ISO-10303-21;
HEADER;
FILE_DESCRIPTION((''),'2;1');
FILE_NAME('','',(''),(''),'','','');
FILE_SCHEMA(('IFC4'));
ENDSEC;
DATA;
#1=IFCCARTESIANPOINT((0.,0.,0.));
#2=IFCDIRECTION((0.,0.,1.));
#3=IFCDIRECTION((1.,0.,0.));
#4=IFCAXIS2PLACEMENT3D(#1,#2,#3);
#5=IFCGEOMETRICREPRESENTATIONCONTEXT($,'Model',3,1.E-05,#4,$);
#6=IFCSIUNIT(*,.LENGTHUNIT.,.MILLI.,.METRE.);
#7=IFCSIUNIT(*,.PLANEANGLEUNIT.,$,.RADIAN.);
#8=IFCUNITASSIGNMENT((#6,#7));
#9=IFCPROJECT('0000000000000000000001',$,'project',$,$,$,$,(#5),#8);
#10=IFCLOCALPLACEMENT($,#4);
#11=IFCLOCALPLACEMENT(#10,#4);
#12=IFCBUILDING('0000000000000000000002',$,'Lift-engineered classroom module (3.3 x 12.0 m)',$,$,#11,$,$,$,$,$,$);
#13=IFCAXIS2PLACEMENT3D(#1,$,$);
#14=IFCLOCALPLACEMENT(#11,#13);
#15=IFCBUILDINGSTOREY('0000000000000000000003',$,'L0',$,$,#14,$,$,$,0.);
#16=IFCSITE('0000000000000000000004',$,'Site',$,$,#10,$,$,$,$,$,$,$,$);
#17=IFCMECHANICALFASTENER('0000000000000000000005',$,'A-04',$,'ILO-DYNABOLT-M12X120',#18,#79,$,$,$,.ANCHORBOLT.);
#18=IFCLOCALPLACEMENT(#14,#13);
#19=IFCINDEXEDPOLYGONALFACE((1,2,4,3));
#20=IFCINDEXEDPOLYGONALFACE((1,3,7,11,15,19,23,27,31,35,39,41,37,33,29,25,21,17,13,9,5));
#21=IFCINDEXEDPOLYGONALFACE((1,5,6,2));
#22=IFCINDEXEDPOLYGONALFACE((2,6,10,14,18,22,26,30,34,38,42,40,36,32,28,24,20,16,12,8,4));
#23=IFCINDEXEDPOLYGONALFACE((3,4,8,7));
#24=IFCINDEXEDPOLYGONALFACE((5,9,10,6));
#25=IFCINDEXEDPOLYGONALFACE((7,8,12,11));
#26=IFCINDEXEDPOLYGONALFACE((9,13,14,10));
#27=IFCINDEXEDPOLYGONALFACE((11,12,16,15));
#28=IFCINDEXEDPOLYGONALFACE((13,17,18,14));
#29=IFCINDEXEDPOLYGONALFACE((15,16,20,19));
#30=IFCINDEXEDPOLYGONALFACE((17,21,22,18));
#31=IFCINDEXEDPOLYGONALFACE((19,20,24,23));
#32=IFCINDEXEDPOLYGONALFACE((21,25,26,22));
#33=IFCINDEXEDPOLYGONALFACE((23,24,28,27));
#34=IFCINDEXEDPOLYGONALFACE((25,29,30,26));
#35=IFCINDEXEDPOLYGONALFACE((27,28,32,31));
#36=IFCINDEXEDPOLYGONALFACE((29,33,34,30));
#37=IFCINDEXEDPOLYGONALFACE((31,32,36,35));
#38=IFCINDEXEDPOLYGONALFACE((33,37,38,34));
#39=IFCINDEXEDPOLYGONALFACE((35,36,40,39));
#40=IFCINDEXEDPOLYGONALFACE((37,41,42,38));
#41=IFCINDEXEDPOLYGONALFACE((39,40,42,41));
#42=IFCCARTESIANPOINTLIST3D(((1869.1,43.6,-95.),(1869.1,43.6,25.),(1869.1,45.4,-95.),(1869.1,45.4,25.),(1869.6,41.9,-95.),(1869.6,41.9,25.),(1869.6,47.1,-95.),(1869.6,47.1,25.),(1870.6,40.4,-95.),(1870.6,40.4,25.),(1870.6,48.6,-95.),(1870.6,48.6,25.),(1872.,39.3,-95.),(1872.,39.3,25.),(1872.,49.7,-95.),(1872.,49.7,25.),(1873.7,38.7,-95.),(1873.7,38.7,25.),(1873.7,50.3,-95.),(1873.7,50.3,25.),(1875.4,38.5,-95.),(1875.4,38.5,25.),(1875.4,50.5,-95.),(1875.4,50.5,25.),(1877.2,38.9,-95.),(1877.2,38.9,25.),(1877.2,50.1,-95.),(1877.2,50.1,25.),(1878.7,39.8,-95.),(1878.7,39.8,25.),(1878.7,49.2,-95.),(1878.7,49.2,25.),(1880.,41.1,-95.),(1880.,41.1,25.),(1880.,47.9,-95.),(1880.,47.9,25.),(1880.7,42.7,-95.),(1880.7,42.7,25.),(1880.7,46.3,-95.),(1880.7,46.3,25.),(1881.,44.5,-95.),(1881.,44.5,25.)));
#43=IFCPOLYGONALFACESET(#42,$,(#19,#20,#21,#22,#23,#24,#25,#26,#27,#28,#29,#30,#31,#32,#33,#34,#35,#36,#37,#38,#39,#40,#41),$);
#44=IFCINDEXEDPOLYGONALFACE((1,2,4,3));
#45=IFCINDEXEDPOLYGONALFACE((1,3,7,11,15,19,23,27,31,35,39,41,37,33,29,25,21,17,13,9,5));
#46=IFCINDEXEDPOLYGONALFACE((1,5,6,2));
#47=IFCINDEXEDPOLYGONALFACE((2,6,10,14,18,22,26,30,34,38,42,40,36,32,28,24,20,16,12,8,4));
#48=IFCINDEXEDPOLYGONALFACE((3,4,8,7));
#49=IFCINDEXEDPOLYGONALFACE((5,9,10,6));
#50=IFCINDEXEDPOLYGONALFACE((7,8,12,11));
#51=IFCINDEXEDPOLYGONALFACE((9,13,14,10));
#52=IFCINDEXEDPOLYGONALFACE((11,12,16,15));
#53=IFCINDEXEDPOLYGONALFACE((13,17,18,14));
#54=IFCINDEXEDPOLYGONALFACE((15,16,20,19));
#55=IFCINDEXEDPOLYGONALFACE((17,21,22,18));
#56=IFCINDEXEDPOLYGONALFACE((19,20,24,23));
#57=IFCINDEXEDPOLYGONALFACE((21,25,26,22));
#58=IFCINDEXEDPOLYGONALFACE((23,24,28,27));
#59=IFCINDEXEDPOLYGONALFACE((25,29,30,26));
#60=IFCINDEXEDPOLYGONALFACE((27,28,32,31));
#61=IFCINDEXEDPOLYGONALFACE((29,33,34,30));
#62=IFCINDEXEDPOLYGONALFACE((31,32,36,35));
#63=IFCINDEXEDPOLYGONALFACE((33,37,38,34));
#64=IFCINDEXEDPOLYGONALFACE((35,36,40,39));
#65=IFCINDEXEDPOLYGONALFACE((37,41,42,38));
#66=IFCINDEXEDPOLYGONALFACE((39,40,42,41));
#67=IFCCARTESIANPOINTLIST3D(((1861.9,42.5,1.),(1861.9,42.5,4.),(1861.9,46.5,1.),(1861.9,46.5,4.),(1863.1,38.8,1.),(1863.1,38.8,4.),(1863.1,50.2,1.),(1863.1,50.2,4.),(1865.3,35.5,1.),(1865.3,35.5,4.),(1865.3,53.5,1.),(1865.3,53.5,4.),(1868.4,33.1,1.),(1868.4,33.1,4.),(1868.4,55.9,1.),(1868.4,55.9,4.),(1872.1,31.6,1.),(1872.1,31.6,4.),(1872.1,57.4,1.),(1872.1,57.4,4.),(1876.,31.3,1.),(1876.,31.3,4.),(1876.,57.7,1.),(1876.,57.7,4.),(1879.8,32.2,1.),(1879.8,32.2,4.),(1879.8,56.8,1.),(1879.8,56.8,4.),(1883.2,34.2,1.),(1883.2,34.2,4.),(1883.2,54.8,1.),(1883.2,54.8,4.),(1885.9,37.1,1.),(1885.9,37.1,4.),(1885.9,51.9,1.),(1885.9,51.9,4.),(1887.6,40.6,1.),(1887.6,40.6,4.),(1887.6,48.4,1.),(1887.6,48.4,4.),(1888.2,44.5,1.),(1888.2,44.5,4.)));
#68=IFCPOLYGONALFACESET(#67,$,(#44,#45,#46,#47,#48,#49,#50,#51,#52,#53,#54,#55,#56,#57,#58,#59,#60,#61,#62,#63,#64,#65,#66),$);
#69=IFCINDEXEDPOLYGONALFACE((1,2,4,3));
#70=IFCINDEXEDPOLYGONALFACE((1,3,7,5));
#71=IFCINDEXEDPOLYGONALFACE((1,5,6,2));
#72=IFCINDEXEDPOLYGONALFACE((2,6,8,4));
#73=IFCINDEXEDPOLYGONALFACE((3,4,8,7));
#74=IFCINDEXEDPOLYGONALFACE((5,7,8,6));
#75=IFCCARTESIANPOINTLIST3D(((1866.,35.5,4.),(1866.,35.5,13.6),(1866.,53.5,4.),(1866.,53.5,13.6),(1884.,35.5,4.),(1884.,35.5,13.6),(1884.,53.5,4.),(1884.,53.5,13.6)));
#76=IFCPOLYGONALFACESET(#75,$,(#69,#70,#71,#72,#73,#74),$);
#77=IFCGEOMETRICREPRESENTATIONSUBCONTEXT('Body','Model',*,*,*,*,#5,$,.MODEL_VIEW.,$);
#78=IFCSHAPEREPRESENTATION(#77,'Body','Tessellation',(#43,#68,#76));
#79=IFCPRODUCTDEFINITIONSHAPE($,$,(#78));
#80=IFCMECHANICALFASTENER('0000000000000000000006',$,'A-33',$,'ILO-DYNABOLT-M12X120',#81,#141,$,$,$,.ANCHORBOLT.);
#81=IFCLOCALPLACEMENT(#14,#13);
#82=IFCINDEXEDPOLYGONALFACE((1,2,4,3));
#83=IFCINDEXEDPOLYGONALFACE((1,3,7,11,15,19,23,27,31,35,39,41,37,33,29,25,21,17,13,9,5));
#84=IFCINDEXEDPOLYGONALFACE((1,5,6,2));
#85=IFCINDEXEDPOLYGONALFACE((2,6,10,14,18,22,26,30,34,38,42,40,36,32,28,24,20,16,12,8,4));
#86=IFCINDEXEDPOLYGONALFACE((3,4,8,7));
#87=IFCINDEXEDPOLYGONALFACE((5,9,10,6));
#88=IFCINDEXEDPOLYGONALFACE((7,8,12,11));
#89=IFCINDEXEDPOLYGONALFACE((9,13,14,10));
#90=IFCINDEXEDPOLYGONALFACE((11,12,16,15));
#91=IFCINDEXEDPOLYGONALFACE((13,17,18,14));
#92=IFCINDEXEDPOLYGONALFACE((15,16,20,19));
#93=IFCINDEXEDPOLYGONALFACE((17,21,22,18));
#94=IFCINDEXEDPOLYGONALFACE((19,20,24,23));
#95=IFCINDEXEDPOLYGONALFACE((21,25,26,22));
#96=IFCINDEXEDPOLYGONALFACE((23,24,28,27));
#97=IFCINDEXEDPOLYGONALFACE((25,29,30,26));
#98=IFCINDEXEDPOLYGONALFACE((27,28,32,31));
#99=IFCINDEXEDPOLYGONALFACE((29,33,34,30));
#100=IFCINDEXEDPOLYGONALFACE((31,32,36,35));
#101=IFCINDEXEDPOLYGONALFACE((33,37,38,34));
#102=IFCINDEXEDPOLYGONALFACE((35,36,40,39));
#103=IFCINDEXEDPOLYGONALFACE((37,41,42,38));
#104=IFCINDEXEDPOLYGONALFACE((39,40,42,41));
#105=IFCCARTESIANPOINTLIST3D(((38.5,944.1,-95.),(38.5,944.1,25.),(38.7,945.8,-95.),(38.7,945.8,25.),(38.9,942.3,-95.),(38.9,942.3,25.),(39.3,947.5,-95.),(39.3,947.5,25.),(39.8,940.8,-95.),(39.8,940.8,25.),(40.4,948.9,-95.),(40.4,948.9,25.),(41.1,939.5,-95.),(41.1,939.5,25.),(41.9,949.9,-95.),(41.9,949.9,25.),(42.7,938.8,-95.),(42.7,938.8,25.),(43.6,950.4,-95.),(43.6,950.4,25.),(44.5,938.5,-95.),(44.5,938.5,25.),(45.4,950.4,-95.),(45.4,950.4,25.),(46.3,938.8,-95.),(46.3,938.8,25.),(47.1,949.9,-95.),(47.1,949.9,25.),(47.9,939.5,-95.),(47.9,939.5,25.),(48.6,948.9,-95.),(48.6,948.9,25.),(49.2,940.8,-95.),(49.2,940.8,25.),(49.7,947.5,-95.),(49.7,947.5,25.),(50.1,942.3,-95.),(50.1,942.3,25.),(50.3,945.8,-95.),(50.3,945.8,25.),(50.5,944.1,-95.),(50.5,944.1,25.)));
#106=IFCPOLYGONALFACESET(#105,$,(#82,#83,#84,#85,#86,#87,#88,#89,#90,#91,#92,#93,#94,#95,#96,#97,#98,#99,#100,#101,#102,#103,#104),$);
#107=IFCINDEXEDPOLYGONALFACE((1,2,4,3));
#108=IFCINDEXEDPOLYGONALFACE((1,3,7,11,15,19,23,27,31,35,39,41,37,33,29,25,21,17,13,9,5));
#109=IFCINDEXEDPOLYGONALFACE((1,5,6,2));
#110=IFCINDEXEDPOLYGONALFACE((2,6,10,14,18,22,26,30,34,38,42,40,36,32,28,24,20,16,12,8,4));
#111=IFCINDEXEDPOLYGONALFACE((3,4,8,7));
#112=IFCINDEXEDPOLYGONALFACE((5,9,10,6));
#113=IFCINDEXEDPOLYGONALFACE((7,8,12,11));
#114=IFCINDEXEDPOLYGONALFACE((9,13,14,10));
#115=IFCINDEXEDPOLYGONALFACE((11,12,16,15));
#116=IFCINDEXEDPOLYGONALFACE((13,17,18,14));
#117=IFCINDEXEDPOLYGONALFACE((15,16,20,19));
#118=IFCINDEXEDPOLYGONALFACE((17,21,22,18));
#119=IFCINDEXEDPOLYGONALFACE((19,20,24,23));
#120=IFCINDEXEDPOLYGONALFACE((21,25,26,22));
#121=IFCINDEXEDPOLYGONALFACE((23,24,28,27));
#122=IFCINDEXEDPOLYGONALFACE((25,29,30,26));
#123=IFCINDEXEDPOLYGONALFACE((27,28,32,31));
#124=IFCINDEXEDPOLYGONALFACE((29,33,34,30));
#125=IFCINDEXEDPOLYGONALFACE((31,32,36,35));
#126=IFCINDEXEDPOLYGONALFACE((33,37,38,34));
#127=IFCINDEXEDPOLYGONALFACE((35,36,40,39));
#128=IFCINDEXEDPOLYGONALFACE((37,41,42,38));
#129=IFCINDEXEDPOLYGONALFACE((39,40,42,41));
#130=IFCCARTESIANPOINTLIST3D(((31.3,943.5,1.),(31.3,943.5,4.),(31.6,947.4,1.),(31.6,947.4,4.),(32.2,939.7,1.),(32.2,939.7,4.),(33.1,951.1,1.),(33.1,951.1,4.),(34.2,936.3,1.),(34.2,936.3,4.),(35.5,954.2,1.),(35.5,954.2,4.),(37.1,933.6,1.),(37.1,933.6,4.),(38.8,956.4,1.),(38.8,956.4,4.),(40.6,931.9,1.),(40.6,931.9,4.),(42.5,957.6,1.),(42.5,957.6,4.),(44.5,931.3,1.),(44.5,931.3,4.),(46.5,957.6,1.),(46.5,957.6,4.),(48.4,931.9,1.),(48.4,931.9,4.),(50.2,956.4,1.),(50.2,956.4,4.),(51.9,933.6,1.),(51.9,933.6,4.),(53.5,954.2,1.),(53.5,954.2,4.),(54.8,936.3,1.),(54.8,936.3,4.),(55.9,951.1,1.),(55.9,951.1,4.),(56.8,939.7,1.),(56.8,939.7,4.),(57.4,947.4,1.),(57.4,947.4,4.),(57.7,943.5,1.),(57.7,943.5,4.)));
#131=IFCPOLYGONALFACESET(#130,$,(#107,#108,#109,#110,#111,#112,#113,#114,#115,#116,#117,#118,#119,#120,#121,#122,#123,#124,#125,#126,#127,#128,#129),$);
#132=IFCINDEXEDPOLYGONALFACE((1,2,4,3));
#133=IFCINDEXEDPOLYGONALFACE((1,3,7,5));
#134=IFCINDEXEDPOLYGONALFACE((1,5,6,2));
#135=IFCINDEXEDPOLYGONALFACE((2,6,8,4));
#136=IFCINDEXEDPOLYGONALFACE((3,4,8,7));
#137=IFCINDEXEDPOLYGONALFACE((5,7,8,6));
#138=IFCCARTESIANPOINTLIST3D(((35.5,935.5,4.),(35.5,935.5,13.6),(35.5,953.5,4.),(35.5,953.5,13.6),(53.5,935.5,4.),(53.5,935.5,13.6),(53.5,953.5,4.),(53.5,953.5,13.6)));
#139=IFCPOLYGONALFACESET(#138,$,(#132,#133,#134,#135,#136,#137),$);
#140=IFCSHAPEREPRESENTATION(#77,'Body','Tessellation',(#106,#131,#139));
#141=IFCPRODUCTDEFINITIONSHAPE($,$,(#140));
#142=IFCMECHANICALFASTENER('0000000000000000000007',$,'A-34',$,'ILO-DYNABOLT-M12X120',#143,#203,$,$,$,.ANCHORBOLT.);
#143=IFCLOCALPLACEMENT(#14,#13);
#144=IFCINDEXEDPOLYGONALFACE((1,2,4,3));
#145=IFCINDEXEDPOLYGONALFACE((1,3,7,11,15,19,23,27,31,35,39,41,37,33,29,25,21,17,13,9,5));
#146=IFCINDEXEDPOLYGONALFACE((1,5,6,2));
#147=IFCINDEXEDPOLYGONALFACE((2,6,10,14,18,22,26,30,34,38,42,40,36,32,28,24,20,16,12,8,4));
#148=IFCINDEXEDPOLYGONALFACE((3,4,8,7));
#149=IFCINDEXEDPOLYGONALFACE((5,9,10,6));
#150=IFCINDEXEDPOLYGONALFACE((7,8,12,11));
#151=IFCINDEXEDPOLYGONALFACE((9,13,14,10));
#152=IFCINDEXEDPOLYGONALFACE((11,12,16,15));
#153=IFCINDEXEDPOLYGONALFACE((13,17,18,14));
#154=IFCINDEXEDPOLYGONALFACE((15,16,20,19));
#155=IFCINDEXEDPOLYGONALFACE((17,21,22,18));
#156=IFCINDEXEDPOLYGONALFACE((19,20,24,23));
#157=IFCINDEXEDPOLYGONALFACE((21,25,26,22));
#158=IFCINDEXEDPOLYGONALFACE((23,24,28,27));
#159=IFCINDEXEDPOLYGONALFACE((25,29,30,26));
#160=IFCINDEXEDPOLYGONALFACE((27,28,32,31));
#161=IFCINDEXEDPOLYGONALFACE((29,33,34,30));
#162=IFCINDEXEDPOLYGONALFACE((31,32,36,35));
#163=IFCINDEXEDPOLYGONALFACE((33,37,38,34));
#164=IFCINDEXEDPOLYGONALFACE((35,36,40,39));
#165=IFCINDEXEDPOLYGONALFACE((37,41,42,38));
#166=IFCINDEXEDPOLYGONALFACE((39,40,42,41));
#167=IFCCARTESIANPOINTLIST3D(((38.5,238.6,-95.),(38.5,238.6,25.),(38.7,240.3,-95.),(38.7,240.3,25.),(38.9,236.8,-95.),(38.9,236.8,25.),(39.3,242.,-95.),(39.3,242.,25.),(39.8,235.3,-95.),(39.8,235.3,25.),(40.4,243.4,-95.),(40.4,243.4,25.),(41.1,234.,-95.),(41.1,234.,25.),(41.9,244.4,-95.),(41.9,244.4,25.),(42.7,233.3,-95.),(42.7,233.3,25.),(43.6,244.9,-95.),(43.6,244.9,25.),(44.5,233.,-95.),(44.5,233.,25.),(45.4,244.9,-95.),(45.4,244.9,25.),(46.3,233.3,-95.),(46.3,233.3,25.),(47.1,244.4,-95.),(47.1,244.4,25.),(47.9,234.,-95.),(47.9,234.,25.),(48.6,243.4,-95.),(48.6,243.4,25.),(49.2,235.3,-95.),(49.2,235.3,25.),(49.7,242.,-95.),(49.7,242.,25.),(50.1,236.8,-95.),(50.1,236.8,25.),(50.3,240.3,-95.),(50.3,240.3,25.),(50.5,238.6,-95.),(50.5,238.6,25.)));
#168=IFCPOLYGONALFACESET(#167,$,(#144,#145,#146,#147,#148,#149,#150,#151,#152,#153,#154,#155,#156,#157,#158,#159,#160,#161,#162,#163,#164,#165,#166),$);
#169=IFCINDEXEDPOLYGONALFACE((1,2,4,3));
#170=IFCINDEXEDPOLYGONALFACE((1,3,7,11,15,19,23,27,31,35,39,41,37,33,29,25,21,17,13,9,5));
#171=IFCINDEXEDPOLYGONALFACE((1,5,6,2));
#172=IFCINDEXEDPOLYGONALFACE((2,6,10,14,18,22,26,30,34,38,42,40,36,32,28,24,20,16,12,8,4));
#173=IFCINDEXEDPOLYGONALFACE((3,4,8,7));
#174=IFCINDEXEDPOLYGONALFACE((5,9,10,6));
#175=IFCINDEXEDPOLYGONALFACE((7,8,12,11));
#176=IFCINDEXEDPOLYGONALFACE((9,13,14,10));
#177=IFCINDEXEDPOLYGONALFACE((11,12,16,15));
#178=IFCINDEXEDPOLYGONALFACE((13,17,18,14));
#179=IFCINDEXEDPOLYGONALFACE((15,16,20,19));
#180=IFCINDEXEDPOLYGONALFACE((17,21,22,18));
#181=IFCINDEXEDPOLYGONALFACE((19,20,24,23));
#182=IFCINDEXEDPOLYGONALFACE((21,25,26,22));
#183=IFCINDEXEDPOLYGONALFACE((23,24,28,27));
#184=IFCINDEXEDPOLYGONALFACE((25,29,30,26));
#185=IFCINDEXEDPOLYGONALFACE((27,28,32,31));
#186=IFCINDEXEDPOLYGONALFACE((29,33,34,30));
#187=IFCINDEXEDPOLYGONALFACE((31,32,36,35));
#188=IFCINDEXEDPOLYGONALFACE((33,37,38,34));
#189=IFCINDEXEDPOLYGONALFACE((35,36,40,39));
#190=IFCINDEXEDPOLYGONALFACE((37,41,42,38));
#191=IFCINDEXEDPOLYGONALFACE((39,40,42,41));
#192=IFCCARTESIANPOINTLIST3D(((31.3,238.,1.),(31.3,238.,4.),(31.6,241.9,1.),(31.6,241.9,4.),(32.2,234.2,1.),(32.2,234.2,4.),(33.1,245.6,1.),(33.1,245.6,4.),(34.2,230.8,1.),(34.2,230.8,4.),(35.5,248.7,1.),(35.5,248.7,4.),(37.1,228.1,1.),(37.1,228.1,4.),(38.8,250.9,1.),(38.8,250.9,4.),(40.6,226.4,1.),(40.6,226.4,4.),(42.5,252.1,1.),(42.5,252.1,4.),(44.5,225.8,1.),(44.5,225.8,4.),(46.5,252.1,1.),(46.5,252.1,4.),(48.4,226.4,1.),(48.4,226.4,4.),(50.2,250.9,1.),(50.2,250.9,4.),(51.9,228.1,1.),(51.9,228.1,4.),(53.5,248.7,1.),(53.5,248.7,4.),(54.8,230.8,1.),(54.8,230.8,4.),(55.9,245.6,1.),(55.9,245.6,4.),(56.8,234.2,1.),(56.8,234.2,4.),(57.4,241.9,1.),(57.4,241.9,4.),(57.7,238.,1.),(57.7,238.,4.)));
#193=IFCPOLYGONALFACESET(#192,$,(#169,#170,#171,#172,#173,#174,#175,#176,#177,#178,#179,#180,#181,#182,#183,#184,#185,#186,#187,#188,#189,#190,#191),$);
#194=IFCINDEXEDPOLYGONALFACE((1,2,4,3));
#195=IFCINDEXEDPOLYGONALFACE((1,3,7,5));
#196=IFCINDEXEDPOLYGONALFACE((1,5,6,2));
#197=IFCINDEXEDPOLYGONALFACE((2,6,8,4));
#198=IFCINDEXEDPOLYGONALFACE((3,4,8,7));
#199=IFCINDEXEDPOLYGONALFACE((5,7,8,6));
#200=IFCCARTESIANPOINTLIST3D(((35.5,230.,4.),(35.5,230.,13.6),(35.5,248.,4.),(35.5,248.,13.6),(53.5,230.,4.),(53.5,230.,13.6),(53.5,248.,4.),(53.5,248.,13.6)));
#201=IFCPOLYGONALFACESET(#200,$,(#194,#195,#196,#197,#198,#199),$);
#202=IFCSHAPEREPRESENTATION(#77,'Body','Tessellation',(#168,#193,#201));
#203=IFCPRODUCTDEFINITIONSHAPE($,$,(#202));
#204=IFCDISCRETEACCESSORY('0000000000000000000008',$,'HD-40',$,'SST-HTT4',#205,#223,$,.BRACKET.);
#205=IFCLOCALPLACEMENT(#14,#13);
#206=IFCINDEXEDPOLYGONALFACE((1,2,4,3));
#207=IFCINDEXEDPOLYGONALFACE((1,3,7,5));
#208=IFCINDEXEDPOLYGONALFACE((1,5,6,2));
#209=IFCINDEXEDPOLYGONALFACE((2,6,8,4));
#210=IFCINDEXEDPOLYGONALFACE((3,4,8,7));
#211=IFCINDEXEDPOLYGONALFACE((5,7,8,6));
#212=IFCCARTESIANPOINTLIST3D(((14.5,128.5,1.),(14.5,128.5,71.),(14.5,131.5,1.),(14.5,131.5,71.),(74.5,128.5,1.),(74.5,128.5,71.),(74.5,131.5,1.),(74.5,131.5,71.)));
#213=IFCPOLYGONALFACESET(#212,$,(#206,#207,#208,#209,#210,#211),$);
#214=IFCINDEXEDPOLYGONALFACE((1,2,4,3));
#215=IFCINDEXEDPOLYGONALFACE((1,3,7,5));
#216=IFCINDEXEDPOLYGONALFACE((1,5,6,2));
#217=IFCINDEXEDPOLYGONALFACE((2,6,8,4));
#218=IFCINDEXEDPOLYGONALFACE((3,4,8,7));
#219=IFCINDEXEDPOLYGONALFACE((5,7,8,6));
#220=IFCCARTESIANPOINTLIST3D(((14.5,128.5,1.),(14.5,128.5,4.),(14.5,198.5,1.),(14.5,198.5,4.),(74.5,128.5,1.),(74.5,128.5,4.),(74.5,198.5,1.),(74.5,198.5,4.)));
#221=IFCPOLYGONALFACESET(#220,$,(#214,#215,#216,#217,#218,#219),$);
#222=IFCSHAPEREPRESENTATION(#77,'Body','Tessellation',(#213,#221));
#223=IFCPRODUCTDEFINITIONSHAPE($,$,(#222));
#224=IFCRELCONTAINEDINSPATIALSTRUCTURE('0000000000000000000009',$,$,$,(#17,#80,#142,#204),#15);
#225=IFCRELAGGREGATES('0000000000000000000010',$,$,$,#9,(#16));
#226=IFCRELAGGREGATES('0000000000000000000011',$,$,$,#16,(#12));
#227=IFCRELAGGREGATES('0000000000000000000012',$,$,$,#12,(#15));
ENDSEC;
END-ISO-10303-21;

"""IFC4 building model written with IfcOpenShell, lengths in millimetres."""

from ifc_helpers import new_model, si_unit, frame, frame_2d, origin, origin_with_axes, origin_2d, place, context, subcontext, project, spatial, rectangle, circle, extrude, element, save


model = new_model("IFC4")

# Units and contexts
model_context = context("Model", 3, precision=1e-05, world=origin_with_axes())
body_context = subcontext(model_context, "Body", "Model", "MODEL_VIEW")
ifc_project = project(units=[si_unit("LENGTHUNIT", "METRE", prefix="MILLI"), si_unit("PLANEANGLEUNIT", "RADIAN")], contexts=[model_context])

# Site, building, storey
site_placement = place(None, origin_with_axes())
site = spatial("IfcSite", under=ifc_project, at=site_placement, Name="Site")
building_placement = place(site_placement, origin_with_axes())
building = spatial("IfcBuilding", under=site, at=building_placement, Name="Lift-engineered classroom module (3.3 x 12.0 m)")
storey_placement = place(building_placement, origin())
storey = spatial("IfcBuildingStorey", under=building, at=storey_placement, Name="L0", Elevation=0.0)

# Mechanical fasteners
for number, where, z_axis, x_axis, name in (
    (1, (1875.0, 44.5, 0.0), (0.0, 0.0, 1.0), (1.0, 0.0, 0.0), "A-04"),
    (2, (44.5, 944.5, 0.0), (0.0, 0.0, 1.0), (0.0, -1.0, 0.0), "A-33"),
    (3, (44.5, 239.0, 0.0), (0.0, 0.0, 1.0), (0.0, -1.0, 0.0), "A-34"),
):
    element("IfcMechanicalFastener", number, at=place(None, frame(where, z_axis=z_axis, x_axis=x_axis)), inside=storey, Name=name, ObjectType="ILO-DYNABOLT-M12X120", PredefinedType="ANCHORBOLT", context=body_context, shape_type="SweptSolid", body=[
        extrude(circle(Radius=6.0, at=origin_2d()), frame((0.0, 0.0, -95.0), z_axis=(0.0, 0.0, 1.0), x_axis=(1.0, 0.0, 0.0)), (0.0, 0.0, 1.0), 120.0),
        extrude(circle(Radius=13.2, at=origin_2d()), frame((0.0, 0.0, 1.0), z_axis=(0.0, 0.0, 1.0), x_axis=(1.0, 0.0, 0.0)), (0.0, 0.0, 1.0), 3.0),
        extrude(rectangle(XDim=18.0, YDim=18.0, at=origin_2d()), frame((0.0, 0.0, 4.0), z_axis=(0.0, 0.0, 1.0), x_axis=(1.0, 0.0, 0.0)), (0.0, 0.0, 1.0), 9.6),
    ])

# Discrete accessory
discrete_accessory_1_placement = place(None, frame((44.5, 128.5, 0.0), z_axis=(0.0, 0.0, 1.0), x_axis=(0.0, 1.0, 0.0)))
element("IfcDiscreteAccessory", 4, at=discrete_accessory_1_placement, inside=storey, Name="HD-40", ObjectType="SST-HTT4", PredefinedType="BRACKET", context=body_context, shape_type="SweptSolid", body=[
    extrude(rectangle(XDim=3.0, YDim=60.0, at=frame_2d((1.5, 0.0))), frame((0.0, 0.0, 1.0), z_axis=(0.0, 0.0, 1.0), x_axis=(1.0, 0.0, 0.0)), (0.0, 0.0, 1.0), 70.0),
    extrude(rectangle(XDim=70.0, YDim=60.0, at=frame_2d((35.0, 0.0))), frame((0.0, 0.0, 1.0), z_axis=(0.0, 0.0, 1.0), x_axis=(1.0, 0.0, 0.0)), (0.0, 0.0, 1.0), 3.0),
])

save(model, "model.ifc")
